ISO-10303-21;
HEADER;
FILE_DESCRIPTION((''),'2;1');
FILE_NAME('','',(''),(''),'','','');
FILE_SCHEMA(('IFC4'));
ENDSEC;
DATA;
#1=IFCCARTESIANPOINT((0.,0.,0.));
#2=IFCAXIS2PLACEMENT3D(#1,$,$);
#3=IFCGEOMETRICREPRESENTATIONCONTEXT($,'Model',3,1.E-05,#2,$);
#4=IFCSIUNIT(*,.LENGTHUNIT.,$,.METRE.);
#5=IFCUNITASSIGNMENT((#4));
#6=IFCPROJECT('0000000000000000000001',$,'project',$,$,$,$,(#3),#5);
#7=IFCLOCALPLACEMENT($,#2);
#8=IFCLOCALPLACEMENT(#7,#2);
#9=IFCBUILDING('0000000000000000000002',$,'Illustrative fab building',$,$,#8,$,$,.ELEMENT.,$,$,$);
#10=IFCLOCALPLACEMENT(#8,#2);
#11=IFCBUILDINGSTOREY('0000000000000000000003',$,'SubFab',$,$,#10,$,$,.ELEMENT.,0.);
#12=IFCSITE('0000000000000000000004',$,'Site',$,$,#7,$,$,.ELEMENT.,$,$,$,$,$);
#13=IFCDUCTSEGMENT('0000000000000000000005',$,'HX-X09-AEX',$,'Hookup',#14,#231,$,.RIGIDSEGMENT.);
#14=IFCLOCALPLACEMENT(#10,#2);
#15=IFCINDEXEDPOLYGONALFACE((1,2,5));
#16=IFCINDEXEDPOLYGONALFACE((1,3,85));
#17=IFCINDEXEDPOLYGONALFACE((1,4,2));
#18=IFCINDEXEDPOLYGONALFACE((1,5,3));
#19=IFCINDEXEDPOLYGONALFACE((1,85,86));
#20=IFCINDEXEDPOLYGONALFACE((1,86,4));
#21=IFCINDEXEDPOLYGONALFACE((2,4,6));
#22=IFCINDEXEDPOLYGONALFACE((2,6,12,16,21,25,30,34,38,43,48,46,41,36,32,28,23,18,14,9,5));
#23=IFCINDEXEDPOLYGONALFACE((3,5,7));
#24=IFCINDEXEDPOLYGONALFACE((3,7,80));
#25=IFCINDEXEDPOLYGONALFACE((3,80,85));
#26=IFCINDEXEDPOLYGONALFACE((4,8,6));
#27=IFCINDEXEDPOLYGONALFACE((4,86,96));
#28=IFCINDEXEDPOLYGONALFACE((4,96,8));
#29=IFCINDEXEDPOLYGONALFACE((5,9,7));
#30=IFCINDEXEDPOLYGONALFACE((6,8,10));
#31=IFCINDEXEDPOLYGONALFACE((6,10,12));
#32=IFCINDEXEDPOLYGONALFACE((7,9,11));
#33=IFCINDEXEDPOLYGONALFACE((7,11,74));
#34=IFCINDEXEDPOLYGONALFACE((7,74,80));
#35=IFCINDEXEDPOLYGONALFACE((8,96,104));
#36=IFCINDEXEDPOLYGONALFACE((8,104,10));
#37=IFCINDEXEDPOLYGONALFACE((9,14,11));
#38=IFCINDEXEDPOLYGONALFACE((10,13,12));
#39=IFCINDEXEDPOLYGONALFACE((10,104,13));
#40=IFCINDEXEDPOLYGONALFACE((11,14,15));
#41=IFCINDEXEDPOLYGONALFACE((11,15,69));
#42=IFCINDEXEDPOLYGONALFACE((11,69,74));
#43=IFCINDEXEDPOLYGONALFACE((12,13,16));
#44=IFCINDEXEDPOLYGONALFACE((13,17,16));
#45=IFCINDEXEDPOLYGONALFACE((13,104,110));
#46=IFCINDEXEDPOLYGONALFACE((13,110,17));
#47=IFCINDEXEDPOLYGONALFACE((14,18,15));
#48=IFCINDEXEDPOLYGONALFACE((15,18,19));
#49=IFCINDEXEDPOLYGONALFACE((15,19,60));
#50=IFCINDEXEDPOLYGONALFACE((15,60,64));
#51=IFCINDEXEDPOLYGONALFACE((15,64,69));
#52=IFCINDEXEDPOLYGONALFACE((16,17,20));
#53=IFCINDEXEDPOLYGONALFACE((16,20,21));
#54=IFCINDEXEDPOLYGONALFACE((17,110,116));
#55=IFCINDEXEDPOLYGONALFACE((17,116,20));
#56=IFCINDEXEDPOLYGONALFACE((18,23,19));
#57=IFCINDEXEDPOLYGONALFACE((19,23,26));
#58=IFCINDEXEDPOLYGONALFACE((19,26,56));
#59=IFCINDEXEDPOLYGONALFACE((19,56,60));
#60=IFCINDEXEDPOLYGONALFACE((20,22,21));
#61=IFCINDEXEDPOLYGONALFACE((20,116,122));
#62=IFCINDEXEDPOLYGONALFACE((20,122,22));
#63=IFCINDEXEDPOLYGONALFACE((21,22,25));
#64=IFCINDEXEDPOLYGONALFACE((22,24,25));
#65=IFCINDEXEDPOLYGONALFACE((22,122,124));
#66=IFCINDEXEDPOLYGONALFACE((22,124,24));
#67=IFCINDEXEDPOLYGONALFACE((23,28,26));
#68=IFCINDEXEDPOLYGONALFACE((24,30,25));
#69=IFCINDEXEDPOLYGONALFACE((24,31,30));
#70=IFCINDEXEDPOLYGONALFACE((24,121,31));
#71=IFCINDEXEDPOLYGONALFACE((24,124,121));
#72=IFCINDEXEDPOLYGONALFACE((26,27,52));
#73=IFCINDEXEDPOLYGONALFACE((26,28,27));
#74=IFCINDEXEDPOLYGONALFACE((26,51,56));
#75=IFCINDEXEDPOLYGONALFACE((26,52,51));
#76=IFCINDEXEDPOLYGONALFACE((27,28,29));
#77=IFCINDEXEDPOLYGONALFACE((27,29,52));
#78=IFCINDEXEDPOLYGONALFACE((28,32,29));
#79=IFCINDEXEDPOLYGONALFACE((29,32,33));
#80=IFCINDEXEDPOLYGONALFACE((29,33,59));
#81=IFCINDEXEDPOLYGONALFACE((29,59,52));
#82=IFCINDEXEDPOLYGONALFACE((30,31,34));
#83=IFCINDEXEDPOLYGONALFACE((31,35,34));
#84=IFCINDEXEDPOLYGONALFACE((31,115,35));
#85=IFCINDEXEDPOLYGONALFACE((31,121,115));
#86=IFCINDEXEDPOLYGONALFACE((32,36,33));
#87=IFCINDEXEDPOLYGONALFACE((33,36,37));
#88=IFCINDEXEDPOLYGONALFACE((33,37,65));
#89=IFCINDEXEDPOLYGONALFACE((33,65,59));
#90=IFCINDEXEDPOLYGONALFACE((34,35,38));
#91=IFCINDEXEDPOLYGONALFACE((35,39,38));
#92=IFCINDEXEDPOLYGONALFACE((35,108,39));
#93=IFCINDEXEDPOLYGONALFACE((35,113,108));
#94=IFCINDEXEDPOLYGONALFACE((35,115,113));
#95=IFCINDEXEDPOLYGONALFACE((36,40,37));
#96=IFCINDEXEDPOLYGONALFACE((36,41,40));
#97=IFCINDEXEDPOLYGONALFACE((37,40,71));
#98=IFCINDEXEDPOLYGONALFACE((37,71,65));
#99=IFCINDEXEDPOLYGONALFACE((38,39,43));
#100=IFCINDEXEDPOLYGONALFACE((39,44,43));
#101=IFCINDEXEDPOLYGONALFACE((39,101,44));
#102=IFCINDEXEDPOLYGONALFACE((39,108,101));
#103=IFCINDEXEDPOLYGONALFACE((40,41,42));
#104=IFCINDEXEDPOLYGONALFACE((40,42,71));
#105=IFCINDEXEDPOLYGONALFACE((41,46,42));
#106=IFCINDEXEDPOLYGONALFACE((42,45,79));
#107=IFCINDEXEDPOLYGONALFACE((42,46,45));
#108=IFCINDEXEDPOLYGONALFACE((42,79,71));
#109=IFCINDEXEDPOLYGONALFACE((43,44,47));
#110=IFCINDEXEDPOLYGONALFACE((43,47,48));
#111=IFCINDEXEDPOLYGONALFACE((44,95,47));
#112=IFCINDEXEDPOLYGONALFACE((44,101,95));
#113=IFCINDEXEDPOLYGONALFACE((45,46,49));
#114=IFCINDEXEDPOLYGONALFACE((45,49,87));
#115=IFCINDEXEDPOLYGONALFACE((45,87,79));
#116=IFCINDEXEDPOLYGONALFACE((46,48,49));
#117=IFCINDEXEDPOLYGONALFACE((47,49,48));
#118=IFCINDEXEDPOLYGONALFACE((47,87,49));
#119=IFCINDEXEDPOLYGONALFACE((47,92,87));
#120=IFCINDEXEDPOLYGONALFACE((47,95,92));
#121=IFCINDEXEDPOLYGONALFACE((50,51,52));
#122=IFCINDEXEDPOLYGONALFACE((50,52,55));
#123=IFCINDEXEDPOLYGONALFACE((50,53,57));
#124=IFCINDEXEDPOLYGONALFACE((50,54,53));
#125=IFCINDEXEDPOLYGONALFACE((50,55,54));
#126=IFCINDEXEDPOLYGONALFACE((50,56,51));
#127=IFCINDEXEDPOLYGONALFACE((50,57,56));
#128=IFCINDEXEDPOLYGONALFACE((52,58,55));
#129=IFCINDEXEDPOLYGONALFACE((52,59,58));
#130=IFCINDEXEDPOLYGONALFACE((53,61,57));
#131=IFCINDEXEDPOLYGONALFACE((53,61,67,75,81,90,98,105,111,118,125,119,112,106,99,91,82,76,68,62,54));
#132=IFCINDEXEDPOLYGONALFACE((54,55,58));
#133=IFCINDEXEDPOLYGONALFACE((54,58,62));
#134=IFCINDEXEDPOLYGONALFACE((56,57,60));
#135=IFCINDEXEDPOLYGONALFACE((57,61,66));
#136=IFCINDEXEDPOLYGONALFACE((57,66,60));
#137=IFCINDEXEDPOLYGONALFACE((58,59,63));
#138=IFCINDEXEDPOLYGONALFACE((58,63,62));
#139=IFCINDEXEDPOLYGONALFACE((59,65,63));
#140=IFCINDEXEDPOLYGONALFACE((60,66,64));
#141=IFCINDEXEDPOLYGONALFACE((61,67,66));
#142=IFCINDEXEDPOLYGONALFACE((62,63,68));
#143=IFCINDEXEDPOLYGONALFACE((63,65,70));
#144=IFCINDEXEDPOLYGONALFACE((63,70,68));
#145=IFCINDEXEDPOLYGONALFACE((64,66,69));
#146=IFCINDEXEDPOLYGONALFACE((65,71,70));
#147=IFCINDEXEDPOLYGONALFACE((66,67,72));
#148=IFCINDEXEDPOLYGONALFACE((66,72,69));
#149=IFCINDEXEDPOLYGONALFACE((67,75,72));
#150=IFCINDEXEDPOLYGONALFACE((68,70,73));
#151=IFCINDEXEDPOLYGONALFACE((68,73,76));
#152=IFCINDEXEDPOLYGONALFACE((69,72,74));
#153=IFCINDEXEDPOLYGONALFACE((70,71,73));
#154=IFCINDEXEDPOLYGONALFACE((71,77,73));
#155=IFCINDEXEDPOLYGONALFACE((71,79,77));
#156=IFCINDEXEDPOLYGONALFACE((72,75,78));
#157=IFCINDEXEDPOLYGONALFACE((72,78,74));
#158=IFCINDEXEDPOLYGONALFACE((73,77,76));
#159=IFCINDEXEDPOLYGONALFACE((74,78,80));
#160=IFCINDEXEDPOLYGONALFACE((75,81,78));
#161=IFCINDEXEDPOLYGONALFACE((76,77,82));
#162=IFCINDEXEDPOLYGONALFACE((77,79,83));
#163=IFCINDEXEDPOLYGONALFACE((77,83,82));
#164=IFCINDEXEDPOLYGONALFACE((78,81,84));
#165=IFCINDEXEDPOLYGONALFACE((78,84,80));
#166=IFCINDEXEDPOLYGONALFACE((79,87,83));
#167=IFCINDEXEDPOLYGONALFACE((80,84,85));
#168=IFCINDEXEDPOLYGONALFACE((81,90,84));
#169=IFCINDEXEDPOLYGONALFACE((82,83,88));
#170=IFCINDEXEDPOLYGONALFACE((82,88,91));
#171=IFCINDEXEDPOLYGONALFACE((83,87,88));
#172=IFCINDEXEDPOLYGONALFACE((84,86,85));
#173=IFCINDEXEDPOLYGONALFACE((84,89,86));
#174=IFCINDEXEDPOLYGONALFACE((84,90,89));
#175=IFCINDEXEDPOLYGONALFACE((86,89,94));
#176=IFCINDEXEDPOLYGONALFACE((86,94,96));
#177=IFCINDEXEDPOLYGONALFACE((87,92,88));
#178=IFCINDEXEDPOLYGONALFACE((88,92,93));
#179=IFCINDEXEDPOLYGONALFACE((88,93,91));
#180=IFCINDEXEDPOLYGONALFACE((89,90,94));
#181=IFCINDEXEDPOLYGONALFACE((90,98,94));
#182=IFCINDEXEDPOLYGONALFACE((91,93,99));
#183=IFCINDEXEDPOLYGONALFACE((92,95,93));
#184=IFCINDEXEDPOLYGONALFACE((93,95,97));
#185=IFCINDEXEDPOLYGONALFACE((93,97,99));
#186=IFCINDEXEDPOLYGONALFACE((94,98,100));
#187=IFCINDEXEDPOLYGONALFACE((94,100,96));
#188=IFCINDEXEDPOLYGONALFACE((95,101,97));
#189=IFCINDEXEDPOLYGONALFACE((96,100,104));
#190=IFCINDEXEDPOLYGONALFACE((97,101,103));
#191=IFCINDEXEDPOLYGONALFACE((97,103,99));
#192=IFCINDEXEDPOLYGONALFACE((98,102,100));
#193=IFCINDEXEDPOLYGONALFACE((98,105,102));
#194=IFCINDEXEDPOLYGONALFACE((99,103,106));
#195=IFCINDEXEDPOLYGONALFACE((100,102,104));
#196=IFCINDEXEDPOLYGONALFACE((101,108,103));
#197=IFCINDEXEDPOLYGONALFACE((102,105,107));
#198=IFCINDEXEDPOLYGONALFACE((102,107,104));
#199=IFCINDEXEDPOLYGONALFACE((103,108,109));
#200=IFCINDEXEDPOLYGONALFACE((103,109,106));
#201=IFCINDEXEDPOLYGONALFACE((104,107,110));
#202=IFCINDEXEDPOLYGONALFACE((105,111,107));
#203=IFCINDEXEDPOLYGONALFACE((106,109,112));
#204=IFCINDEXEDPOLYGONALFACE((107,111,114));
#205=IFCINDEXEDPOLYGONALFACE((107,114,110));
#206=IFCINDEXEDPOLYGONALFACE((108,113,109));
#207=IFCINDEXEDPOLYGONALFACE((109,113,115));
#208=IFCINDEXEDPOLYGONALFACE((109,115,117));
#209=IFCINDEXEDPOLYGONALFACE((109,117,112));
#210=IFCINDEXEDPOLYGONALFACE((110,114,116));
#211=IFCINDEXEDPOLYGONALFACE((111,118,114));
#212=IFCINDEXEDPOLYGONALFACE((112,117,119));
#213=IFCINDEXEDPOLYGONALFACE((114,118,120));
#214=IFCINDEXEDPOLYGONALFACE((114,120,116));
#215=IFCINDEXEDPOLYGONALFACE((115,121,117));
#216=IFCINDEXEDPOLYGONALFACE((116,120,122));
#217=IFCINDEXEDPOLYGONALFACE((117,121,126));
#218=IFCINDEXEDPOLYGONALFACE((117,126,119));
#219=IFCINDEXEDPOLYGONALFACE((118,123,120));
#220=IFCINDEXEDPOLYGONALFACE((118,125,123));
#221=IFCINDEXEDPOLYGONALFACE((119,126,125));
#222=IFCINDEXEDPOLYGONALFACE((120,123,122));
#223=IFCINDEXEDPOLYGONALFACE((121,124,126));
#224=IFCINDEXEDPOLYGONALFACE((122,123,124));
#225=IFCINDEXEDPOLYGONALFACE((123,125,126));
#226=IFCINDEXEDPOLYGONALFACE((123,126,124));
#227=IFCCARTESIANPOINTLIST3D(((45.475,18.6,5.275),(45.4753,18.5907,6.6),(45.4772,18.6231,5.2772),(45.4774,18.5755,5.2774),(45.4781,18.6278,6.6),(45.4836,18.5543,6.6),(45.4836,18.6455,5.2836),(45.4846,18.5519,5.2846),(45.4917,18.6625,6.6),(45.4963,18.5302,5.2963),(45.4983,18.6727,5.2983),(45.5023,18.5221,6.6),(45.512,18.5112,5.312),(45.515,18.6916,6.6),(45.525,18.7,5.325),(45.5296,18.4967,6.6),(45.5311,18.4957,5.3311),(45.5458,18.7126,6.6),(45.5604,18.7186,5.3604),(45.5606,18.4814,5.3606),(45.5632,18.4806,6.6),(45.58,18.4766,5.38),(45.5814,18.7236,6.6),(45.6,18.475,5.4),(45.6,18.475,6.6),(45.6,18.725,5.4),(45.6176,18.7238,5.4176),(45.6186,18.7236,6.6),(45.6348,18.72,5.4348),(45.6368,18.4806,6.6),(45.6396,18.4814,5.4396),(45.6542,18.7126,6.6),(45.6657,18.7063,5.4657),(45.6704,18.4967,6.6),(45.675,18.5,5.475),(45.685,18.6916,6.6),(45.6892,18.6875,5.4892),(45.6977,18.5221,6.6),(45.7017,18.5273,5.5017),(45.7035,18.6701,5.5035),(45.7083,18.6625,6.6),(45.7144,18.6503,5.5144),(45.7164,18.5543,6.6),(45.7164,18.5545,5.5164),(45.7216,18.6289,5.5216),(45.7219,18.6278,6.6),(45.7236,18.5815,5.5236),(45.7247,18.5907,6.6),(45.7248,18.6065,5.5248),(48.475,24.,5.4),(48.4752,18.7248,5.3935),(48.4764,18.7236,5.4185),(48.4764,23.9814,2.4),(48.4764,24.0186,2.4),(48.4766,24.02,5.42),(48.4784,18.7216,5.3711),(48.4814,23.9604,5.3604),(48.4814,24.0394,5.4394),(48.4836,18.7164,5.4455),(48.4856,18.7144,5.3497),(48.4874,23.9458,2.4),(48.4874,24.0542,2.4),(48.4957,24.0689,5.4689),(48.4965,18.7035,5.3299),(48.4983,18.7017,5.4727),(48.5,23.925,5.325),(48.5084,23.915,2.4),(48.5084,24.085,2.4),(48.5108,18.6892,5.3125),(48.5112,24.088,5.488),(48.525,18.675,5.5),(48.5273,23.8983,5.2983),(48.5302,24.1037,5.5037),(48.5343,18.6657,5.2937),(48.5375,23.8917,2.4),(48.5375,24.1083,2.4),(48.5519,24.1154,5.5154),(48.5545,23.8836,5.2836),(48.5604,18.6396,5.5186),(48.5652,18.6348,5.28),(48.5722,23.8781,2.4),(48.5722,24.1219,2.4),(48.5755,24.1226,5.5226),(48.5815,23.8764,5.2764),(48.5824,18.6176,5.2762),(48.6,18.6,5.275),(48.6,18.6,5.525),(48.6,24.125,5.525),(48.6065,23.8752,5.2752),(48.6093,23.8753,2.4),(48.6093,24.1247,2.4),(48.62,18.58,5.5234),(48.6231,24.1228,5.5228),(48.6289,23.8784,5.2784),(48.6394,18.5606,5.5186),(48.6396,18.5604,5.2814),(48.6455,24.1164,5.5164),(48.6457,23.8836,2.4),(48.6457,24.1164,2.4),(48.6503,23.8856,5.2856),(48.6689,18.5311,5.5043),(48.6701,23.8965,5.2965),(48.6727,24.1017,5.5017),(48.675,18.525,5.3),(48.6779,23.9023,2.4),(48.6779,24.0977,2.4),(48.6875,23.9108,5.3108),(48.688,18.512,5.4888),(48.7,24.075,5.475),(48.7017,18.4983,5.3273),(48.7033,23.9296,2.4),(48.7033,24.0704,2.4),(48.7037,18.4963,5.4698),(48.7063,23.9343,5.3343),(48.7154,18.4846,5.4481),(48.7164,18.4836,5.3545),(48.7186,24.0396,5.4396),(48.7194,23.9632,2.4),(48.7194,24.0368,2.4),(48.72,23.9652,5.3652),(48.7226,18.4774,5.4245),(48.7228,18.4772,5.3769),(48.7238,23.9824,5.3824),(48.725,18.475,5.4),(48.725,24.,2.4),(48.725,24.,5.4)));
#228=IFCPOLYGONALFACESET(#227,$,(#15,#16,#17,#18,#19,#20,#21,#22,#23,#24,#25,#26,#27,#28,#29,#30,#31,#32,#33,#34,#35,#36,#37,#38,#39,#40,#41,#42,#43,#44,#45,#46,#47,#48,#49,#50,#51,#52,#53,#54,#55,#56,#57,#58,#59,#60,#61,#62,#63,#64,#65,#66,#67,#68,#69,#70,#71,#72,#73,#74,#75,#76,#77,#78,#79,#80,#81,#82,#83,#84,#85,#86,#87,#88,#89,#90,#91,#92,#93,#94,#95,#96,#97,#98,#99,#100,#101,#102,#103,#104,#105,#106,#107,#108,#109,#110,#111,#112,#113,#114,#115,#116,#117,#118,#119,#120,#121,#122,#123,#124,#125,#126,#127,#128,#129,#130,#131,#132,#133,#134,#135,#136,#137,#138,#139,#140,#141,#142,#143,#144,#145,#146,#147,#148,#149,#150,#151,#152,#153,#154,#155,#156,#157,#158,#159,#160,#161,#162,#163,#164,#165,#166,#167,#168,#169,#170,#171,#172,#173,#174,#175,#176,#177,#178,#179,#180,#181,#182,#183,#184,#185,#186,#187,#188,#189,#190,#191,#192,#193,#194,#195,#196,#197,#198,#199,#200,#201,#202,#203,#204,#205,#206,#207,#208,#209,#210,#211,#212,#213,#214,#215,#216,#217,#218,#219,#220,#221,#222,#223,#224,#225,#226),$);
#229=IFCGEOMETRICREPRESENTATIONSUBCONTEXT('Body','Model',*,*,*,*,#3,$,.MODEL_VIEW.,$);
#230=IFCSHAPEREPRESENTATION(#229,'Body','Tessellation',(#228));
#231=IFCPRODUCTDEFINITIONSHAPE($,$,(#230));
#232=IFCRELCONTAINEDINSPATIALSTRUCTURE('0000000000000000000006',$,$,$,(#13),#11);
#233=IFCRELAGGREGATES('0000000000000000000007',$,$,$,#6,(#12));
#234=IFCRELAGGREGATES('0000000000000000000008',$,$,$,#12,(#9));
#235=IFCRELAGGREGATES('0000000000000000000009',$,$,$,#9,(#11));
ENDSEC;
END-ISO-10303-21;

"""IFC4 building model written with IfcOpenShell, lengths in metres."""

from ifc_helpers import new_model, entity, si_unit, origin, place, context, subcontext, project, spatial, element, save


model = new_model("IFC4")

# Units and contexts
model_context = context("Model", 3, precision=1e-05, world=origin())
body_context = subcontext(model_context, "Body", "Model", "MODEL_VIEW")
ifc_project = project(units=[si_unit("LENGTHUNIT", "METRE")], contexts=[model_context])

# Site, building, storey
site_placement = place(None, origin())
site = spatial("IfcSite", under=ifc_project, at=site_placement, Name="Site", CompositionType="ELEMENT")
building_placement = place(site_placement, origin())
building = spatial("IfcBuilding", under=site, at=building_placement, Name="Illustrative fab building", CompositionType="ELEMENT")
storey_placement = place(building_placement, origin())
storey = spatial("IfcBuildingStorey", under=building, at=storey_placement, Name="SubFab", CompositionType="ELEMENT", Elevation=0.0)

# Duct segment
duct_segment_1_placement = place(storey_placement, origin())
element("IfcDuctSegment", 1, at=duct_segment_1_placement, inside=storey, Name="HX-X09-AEX", ObjectType="Hookup", PredefinedType="RIGIDSEGMENT", context=body_context, shape_type="AdvancedSweptSolid", body=[
    entity("IfcSweptDiskSolid", entity("IfcPolyline", [entity("IfcCartesianPoint", [48.6, 24.0, 2.4]), entity("IfcCartesianPoint", [48.6, 24.0, 5.4]), entity("IfcCartesianPoint", [48.6, 18.6, 5.4]), entity("IfcCartesianPoint", [45.6, 18.6, 5.4]), entity("IfcCartesianPoint", [45.6, 18.6, 6.6])]), 0.125),
])

save(model, "model.ifc")
